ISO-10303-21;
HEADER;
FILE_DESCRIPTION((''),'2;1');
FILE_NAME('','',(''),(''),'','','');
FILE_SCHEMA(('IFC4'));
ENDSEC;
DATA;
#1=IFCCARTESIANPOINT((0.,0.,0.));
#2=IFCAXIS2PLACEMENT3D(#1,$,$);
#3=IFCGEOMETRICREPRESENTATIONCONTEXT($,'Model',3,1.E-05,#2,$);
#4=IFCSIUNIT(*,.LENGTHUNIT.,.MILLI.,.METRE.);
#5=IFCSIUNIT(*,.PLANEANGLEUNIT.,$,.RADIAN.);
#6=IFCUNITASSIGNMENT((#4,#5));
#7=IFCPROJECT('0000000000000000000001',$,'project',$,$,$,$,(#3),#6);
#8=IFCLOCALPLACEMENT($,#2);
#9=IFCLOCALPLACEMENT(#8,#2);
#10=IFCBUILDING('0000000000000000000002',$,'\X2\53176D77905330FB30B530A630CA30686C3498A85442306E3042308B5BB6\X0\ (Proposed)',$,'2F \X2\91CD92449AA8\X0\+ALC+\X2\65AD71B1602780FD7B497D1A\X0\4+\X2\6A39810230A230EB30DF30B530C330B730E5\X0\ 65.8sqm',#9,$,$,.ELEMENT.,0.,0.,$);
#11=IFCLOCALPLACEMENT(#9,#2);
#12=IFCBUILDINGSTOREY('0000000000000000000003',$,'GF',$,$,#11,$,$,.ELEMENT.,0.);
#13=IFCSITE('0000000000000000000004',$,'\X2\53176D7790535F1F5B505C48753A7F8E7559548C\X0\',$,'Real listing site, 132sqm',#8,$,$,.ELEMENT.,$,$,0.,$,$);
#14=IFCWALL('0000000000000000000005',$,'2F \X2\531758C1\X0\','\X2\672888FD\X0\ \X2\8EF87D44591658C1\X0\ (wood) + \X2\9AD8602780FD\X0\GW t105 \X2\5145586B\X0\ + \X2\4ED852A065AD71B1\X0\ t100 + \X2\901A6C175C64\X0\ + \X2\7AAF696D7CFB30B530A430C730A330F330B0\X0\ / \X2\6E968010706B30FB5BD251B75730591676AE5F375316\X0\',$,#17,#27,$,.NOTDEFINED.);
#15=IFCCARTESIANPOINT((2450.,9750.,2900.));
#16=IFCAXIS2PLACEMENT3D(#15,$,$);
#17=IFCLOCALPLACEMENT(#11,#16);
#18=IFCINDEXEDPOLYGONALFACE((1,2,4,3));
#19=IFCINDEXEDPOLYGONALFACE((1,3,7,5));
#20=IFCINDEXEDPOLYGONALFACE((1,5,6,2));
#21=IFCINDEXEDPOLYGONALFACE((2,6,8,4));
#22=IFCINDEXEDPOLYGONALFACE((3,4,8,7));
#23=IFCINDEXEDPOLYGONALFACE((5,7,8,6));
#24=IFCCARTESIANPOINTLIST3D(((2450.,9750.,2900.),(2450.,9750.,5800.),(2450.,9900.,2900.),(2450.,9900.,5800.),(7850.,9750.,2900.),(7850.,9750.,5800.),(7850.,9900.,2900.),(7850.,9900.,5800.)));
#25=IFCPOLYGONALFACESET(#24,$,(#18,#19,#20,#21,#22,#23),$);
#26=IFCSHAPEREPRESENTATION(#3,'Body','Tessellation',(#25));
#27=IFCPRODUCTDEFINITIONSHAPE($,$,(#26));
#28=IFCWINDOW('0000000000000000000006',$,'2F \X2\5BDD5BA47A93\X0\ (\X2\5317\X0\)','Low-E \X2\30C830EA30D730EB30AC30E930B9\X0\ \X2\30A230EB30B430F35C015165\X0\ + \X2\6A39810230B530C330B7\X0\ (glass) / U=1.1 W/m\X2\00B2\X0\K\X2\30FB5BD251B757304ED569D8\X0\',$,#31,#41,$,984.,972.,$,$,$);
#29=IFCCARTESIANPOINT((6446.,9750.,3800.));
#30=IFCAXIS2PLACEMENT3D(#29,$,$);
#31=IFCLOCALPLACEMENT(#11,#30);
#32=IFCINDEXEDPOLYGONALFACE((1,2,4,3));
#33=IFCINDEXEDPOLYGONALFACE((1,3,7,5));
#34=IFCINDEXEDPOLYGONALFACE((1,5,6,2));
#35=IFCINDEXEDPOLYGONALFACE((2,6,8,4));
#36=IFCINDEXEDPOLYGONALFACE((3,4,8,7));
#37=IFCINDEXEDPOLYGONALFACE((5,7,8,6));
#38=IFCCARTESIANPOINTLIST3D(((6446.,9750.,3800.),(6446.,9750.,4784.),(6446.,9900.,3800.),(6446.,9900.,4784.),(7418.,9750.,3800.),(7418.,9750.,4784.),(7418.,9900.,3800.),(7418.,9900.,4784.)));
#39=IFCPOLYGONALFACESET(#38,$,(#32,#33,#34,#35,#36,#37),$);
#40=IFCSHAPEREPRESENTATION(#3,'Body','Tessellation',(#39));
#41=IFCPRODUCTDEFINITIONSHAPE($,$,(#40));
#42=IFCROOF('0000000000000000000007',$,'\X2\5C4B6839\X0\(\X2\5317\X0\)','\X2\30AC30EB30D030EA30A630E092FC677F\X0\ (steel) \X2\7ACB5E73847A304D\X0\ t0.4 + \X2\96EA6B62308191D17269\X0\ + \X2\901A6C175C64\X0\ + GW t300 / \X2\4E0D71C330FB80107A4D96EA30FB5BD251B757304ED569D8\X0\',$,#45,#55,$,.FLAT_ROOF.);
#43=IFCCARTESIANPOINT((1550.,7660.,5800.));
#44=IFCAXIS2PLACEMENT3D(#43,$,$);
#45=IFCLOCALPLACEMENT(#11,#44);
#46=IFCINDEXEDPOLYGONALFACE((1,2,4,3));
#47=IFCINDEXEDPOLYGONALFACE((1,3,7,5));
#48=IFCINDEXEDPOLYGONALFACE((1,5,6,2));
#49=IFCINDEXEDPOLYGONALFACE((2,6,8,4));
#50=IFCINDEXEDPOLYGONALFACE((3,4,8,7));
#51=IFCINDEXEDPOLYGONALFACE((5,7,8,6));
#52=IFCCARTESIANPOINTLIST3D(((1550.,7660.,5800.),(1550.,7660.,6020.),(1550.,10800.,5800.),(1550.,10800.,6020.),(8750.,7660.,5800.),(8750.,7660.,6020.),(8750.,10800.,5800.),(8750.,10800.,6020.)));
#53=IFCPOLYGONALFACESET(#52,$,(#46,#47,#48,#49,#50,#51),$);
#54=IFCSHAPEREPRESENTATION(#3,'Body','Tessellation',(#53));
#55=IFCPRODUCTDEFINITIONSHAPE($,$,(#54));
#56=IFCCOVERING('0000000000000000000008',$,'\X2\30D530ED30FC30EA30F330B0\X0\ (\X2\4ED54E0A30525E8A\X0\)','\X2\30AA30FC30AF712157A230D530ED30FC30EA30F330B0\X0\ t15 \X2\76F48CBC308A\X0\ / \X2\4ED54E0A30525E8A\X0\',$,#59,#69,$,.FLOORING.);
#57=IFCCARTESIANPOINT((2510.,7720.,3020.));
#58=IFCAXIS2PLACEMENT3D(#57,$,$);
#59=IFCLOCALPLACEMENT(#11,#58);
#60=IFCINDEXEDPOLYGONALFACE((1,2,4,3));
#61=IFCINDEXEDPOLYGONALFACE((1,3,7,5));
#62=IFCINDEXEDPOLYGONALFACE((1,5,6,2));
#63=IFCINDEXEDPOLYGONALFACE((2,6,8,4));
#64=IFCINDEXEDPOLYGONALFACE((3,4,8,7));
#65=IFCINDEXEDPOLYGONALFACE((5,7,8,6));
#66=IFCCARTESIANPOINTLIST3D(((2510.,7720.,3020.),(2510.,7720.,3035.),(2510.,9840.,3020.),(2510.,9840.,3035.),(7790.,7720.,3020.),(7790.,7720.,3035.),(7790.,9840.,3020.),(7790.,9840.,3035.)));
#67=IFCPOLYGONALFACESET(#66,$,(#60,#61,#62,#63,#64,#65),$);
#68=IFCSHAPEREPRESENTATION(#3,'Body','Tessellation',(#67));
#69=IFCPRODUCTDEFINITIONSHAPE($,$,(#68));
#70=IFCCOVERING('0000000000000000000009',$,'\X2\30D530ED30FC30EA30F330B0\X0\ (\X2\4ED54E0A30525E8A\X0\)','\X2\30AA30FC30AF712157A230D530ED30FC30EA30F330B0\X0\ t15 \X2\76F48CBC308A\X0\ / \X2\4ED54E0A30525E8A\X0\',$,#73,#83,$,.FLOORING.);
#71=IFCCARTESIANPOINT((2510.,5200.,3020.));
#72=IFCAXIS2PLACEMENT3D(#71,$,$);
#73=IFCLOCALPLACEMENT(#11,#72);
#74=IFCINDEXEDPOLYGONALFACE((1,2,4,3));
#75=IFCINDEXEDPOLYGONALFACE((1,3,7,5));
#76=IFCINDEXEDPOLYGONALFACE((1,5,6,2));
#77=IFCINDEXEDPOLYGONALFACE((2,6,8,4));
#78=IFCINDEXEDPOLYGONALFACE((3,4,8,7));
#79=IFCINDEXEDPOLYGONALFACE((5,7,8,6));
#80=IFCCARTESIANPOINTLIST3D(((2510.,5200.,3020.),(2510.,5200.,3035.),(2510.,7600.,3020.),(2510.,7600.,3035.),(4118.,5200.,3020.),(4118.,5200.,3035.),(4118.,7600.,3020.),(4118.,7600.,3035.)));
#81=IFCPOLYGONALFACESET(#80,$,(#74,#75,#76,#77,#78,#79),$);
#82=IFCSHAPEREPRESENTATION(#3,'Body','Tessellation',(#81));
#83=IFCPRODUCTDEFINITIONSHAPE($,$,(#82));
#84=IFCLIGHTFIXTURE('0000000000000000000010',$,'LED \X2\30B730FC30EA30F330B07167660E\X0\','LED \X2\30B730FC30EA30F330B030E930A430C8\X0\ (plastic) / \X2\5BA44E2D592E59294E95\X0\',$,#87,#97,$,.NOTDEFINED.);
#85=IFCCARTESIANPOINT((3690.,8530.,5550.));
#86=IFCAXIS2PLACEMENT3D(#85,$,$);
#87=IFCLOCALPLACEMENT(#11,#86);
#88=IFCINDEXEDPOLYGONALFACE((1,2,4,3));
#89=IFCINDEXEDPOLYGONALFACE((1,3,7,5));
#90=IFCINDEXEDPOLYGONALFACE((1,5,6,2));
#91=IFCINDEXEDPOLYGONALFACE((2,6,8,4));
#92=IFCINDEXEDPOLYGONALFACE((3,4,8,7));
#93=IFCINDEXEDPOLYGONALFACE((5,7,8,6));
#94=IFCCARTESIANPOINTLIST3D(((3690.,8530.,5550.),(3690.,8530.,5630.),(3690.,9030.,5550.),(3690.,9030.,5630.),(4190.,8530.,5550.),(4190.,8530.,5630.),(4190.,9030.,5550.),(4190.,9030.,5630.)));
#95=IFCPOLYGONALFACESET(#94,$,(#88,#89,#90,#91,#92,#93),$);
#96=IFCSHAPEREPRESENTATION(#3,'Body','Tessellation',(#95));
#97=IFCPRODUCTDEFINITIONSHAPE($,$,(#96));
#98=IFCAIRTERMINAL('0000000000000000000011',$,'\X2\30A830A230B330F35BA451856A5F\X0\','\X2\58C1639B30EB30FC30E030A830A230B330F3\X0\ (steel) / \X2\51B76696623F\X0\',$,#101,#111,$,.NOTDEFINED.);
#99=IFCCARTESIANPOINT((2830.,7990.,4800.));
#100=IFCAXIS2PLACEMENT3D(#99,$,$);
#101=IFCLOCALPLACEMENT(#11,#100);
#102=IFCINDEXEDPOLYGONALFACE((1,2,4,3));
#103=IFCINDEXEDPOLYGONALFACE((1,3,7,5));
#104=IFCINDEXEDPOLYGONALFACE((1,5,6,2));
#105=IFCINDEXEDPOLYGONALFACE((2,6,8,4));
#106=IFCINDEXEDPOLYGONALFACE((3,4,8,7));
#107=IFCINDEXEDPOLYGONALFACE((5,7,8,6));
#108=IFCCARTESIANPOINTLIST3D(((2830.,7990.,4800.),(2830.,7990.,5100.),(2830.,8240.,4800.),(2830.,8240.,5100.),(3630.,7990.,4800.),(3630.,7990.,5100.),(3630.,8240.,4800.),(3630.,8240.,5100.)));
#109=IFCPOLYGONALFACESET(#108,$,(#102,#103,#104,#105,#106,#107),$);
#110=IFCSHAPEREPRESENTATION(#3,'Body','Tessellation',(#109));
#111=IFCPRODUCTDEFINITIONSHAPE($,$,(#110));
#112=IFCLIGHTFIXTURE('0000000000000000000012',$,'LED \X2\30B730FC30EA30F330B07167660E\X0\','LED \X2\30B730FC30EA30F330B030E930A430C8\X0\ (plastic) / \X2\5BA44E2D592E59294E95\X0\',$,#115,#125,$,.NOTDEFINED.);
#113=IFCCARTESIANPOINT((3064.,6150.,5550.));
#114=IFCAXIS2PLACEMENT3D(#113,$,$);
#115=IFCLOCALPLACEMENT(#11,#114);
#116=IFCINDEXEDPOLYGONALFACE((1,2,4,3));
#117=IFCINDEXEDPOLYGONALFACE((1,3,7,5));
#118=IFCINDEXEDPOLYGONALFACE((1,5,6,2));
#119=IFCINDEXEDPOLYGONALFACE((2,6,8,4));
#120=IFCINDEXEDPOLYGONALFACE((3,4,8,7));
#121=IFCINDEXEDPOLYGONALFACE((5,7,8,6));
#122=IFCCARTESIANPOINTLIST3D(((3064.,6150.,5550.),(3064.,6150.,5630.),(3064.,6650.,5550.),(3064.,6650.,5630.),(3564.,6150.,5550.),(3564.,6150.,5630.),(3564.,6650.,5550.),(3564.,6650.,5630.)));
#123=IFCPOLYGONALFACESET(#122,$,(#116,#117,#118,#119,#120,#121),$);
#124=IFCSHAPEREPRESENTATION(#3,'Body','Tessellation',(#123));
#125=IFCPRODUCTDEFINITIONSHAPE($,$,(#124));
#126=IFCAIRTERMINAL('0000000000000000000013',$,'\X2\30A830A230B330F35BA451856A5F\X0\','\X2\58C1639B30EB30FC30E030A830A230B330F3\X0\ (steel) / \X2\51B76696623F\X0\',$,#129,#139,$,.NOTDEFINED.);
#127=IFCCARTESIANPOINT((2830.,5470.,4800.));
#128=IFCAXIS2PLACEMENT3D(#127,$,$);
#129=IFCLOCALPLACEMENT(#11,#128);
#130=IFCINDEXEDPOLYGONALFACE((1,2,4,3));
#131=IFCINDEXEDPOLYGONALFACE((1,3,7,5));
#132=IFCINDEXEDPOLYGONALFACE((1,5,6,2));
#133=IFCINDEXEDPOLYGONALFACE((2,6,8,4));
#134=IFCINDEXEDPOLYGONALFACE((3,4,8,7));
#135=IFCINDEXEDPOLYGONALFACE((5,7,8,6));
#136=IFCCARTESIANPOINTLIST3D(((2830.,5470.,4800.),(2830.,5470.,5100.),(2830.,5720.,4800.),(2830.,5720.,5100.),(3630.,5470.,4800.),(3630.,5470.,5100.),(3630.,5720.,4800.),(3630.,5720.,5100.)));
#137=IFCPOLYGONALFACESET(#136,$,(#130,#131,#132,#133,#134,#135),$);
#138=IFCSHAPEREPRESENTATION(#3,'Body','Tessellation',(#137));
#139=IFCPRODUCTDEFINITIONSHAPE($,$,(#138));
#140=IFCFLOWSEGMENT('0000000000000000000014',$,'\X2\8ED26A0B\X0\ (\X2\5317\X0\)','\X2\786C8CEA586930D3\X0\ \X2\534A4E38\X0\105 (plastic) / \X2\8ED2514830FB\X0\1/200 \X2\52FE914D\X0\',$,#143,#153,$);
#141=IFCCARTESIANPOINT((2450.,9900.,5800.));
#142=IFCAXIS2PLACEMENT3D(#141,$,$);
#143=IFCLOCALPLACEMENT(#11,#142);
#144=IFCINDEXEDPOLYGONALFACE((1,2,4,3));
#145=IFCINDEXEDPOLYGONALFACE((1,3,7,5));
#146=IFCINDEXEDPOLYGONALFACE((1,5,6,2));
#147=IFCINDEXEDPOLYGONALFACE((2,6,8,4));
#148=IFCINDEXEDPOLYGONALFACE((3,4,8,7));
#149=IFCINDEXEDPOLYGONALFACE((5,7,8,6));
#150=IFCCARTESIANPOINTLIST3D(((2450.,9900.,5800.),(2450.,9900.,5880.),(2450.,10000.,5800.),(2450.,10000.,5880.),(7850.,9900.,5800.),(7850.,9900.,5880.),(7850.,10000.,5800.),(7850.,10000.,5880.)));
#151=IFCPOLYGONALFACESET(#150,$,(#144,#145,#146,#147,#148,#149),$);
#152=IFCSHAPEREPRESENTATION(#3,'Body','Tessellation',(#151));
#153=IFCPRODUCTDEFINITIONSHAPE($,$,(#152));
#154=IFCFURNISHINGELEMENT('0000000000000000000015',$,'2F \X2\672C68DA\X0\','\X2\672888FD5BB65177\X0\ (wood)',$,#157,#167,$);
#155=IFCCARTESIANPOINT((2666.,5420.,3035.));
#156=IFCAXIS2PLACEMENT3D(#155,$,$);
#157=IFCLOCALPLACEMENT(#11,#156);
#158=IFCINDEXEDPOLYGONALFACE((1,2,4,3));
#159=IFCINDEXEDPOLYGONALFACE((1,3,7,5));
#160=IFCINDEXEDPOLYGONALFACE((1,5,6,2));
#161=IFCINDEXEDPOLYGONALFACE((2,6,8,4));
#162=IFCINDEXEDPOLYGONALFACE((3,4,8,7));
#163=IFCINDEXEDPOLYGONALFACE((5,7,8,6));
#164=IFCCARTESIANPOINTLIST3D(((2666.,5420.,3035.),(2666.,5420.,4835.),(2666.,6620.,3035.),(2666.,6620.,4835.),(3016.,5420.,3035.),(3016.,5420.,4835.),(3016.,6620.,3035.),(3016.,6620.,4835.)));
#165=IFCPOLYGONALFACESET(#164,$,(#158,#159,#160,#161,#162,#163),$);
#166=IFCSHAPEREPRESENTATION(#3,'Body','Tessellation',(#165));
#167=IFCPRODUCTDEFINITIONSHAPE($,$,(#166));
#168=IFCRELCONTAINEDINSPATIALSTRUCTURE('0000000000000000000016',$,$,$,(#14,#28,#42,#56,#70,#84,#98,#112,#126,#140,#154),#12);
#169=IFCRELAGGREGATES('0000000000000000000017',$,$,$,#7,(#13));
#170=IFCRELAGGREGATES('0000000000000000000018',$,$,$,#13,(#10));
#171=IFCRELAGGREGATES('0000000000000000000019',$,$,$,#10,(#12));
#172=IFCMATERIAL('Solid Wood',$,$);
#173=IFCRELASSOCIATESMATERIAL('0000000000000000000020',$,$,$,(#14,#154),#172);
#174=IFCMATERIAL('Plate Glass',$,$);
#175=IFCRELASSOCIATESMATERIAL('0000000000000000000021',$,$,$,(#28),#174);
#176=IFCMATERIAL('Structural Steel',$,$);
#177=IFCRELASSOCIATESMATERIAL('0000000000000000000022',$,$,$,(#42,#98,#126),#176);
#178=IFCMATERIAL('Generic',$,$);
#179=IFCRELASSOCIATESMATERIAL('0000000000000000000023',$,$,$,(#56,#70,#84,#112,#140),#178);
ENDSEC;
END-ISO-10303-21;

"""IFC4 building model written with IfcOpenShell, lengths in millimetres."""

from ifc_helpers import new_model, si_unit, frame, frame_2d, origin, place, context, project, spatial, rectangle, extrude, material, element, fill, save


model = new_model("IFC4")

# Units and contexts
model_context = context("Model", 3, precision=1e-05, world=origin())
ifc_project = project(units=[si_unit("LENGTHUNIT", "METRE", prefix="MILLI"), si_unit("PLANEANGLEUNIT", "RADIAN")], contexts=[model_context])

# Site, building, storey
site_placement = place(None, origin())
site = spatial("IfcSite", under=ifc_project, at=site_placement, Name="北海道弟子屈町美留和", ObjectType="Real listing site, 132sqm", CompositionType="ELEMENT", RefElevation=0.0)
building_placement = place(site_placement, origin())
building = spatial("IfcBuilding", under=site, at=building_placement, Name="北海道・サウナと水風呂のある家 (Proposed)", ObjectType="2F 重鉄骨+ALC+断熱性能等級4+樹脂アルミサッシュ 65.8sqm", CompositionType="ELEMENT", ElevationOfRefHeight=0.0, ElevationOfTerrain=0.0)
storey_placement = place(building_placement, origin())
storey = spatial("IfcBuildingStorey", under=building, at=storey_placement, Name="GF", CompositionType="ELEMENT", Elevation=0.0)

# Shared definitions
ifc_material_1 = material(Name="Solid Wood")

# Wall, opening, window
wall_placement = place(storey_placement, frame((2450.0, 9750.0, 2900.0)))
wall = element("IfcWall", 1, at=wall_placement, inside=storey, material=ifc_material_1, Name="2F 北壁", Description="木製 軸組外壁 (wood) + 高性能GW t105 充填 + 付加断熱 t100 + 通気層 + 窯業系サイディング / 準耐火・寒冷地外皮強化", PredefinedType="NOTDEFINED", context=model_context, shape_type="SweptSolid", body=[
    extrude(rectangle(XDim=5400.0, YDim=150.0, at=frame_2d((2700.0, 75.0))), frame((2450.0, 9750.0, 2900.0)), (0.0, 0.0, 1.0), 2900.0),
])
opening_placement = place(storey_placement, frame((6446.0, 9750.0, 3800.0)))
opening = element("IfcOpeningElement", 2, at=opening_placement, cuts=wall, PredefinedType="NOTDEFINED", context=model_context, shape_type="SweptSolid", body=[
    extrude(rectangle(XDim=972.0, YDim=150.0, at=frame_2d((486.0, 75.0))), frame((6446.0, 9750.0, 3800.0)), (0.0, 0.0, 1.0), 984.0),
])
ifc_material_2 = material(Name="Plate Glass")
window_placement = place(storey_placement, frame((6446.0, 9750.0, 3800.0)))
window = element("IfcWindow", 3, at=window_placement, inside=storey, material=ifc_material_2, Name="2F 寝室窓 (北)", Description="Low-E トリプルガラス アルゴン封入 + 樹脂サッシ (glass) / U=1.1 W/m²K・寒冷地仕様", OverallHeight=984.0, OverallWidth=972.0, context=model_context, shape_type="SweptSolid", body=[
    extrude(rectangle(XDim=972.0, YDim=150.0, at=frame_2d((486.0, 75.0))), frame((6446.0, 9750.0, 3800.0)), (0.0, 0.0, 1.0), 984.0),
])
fill(opening, window)

# Roof
ifc_material_3 = material(Name="Structural Steel")
for number, where, name in (
    (4, (1550.0, 7660.0, 5800.0), "屋根(北)"),
):
    element("IfcRoof", number, at=place(storey_placement, frame(where)), inside=storey, material=ifc_material_3, Name=name, Description="ガルバリウム鋼板 (steel) 立平葺き t0.4 + 雪止め金物 + 通気層 + GW t300 / 不燃・耐積雪・寒冷地仕様", PredefinedType="FLAT_ROOF", context=model_context, shape_type="SweptSolid", body=[
        extrude(rectangle(XDim=7200.0, YDim=3140.0, at=frame_2d((3600.0, 1570.0))), frame((1550.0, 7660.0, 5800.0)), (0.0, 0.0, 1.0), 220.0),
    ])

# Coverings
ifc_material_4 = material(Name="Generic")
covering_1_placement = place(storey_placement, frame((2510.0, 7720.0, 3020.0)))
element("IfcCovering", 5, at=covering_1_placement, inside=storey, material=ifc_material_4, Name="フローリング (仕上げ床)", Description="オーク無垢フローリング t15 直貼り / 仕上げ床", PredefinedType="FLOORING", context=model_context, shape_type="SweptSolid", body=[
    extrude(rectangle(XDim=5280.0, YDim=2120.0, at=frame_2d((2640.0, 1060.0))), frame((2510.0, 7720.0, 3020.0)), (0.0, 0.0, 1.0), 15.0),
])
covering_2_placement = place(storey_placement, frame((2510.0, 5200.0, 3020.0)))
element("IfcCovering", 6, at=covering_2_placement, inside=storey, material=ifc_material_4, Name="フローリング (仕上げ床)", Description="オーク無垢フローリング t15 直貼り / 仕上げ床", PredefinedType="FLOORING", context=model_context, shape_type="SweptSolid", body=[
    extrude(rectangle(XDim=1608.0, YDim=2400.0, at=frame_2d((804.0, 1200.0))), frame((2510.0, 5200.0, 3020.0)), (0.0, 0.0, 1.0), 15.0),
])

# Light fixture
light_fixture_1_placement = place(storey_placement, frame((3690.0, 8530.0, 5550.0)))
element("IfcLightFixture", 7, at=light_fixture_1_placement, inside=storey, material=ifc_material_4, Name="LED シーリング照明", Description="LED シーリングライト (plastic) / 室中央天井", PredefinedType="NOTDEFINED", context=model_context, shape_type="SweptSolid", body=[
    extrude(rectangle(XDim=500.0, YDim=500.0, at=frame_2d((250.0, 250.0))), frame((3690.0, 8530.0, 5550.0)), (0.0, 0.0, 1.0), 80.0),
])

# Air terminal
air_terminal_1_placement = place(storey_placement, frame((2830.0, 7990.0, 4800.0)))
element("IfcAirTerminal", 8, at=air_terminal_1_placement, inside=storey, material=ifc_material_3, Name="エアコン室内機", Description="壁掛ルームエアコン (steel) / 冷暖房", PredefinedType="NOTDEFINED", context=model_context, shape_type="SweptSolid", body=[
    extrude(rectangle(XDim=800.0, YDim=250.0, at=frame_2d((400.0, 125.0))), frame((2830.0, 7990.0, 4800.0)), (0.0, 0.0, 1.0), 300.0),
])

# Light fixture
light_fixture_2_placement = place(storey_placement, frame((3064.0, 6150.0, 5550.0)))
element("IfcLightFixture", 9, at=light_fixture_2_placement, inside=storey, material=ifc_material_4, Name="LED シーリング照明", Description="LED シーリングライト (plastic) / 室中央天井", PredefinedType="NOTDEFINED", context=model_context, shape_type="SweptSolid", body=[
    extrude(rectangle(XDim=500.0, YDim=500.0, at=frame_2d((250.0, 250.0))), frame((3064.0, 6150.0, 5550.0)), (0.0, 0.0, 1.0), 80.0),
])

# Air terminal
air_terminal_2_placement = place(storey_placement, frame((2830.0, 5470.0, 4800.0)))
element("IfcAirTerminal", 10, at=air_terminal_2_placement, inside=storey, material=ifc_material_3, Name="エアコン室内機", Description="壁掛ルームエアコン (steel) / 冷暖房", PredefinedType="NOTDEFINED", context=model_context, shape_type="SweptSolid", body=[
    extrude(rectangle(XDim=800.0, YDim=250.0, at=frame_2d((400.0, 125.0))), frame((2830.0, 5470.0, 4800.0)), (0.0, 0.0, 1.0), 300.0),
])

# Flow segment
flow_segment_placement = place(storey_placement, frame((2450.0, 9900.0, 5800.0)))
element("IfcFlowSegment", 11, at=flow_segment_placement, inside=storey, material=ifc_material_4, Name="軒樋 (北)", Description="硬質塩ビ 半丸105 (plastic) / 軒先・1/200 勾配", context=model_context, shape_type="SweptSolid", body=[
    extrude(rectangle(XDim=5400.0, YDim=100.0, at=frame_2d((2700.0, 50.0))), frame((2450.0, 9900.0, 5800.0)), (0.0, 0.0, 1.0), 80.0),
])

# Furnishing element
furnishing_placement = place(storey_placement, frame((2666.0, 5420.0, 3035.0)))
element("IfcFurnishingElement", 12, at=furnishing_placement, inside=storey, material=ifc_material_1, Name="2F 本棚", Description="木製家具 (wood)", context=model_context, shape_type="SweptSolid", body=[
    extrude(rectangle(XDim=350.0, YDim=1200.0, at=frame_2d((175.0, 600.0))), frame((2666.0, 5420.0, 3035.0)), (0.0, 0.0, 1.0), 1800.0),
])

save(model, "model.ifc")
